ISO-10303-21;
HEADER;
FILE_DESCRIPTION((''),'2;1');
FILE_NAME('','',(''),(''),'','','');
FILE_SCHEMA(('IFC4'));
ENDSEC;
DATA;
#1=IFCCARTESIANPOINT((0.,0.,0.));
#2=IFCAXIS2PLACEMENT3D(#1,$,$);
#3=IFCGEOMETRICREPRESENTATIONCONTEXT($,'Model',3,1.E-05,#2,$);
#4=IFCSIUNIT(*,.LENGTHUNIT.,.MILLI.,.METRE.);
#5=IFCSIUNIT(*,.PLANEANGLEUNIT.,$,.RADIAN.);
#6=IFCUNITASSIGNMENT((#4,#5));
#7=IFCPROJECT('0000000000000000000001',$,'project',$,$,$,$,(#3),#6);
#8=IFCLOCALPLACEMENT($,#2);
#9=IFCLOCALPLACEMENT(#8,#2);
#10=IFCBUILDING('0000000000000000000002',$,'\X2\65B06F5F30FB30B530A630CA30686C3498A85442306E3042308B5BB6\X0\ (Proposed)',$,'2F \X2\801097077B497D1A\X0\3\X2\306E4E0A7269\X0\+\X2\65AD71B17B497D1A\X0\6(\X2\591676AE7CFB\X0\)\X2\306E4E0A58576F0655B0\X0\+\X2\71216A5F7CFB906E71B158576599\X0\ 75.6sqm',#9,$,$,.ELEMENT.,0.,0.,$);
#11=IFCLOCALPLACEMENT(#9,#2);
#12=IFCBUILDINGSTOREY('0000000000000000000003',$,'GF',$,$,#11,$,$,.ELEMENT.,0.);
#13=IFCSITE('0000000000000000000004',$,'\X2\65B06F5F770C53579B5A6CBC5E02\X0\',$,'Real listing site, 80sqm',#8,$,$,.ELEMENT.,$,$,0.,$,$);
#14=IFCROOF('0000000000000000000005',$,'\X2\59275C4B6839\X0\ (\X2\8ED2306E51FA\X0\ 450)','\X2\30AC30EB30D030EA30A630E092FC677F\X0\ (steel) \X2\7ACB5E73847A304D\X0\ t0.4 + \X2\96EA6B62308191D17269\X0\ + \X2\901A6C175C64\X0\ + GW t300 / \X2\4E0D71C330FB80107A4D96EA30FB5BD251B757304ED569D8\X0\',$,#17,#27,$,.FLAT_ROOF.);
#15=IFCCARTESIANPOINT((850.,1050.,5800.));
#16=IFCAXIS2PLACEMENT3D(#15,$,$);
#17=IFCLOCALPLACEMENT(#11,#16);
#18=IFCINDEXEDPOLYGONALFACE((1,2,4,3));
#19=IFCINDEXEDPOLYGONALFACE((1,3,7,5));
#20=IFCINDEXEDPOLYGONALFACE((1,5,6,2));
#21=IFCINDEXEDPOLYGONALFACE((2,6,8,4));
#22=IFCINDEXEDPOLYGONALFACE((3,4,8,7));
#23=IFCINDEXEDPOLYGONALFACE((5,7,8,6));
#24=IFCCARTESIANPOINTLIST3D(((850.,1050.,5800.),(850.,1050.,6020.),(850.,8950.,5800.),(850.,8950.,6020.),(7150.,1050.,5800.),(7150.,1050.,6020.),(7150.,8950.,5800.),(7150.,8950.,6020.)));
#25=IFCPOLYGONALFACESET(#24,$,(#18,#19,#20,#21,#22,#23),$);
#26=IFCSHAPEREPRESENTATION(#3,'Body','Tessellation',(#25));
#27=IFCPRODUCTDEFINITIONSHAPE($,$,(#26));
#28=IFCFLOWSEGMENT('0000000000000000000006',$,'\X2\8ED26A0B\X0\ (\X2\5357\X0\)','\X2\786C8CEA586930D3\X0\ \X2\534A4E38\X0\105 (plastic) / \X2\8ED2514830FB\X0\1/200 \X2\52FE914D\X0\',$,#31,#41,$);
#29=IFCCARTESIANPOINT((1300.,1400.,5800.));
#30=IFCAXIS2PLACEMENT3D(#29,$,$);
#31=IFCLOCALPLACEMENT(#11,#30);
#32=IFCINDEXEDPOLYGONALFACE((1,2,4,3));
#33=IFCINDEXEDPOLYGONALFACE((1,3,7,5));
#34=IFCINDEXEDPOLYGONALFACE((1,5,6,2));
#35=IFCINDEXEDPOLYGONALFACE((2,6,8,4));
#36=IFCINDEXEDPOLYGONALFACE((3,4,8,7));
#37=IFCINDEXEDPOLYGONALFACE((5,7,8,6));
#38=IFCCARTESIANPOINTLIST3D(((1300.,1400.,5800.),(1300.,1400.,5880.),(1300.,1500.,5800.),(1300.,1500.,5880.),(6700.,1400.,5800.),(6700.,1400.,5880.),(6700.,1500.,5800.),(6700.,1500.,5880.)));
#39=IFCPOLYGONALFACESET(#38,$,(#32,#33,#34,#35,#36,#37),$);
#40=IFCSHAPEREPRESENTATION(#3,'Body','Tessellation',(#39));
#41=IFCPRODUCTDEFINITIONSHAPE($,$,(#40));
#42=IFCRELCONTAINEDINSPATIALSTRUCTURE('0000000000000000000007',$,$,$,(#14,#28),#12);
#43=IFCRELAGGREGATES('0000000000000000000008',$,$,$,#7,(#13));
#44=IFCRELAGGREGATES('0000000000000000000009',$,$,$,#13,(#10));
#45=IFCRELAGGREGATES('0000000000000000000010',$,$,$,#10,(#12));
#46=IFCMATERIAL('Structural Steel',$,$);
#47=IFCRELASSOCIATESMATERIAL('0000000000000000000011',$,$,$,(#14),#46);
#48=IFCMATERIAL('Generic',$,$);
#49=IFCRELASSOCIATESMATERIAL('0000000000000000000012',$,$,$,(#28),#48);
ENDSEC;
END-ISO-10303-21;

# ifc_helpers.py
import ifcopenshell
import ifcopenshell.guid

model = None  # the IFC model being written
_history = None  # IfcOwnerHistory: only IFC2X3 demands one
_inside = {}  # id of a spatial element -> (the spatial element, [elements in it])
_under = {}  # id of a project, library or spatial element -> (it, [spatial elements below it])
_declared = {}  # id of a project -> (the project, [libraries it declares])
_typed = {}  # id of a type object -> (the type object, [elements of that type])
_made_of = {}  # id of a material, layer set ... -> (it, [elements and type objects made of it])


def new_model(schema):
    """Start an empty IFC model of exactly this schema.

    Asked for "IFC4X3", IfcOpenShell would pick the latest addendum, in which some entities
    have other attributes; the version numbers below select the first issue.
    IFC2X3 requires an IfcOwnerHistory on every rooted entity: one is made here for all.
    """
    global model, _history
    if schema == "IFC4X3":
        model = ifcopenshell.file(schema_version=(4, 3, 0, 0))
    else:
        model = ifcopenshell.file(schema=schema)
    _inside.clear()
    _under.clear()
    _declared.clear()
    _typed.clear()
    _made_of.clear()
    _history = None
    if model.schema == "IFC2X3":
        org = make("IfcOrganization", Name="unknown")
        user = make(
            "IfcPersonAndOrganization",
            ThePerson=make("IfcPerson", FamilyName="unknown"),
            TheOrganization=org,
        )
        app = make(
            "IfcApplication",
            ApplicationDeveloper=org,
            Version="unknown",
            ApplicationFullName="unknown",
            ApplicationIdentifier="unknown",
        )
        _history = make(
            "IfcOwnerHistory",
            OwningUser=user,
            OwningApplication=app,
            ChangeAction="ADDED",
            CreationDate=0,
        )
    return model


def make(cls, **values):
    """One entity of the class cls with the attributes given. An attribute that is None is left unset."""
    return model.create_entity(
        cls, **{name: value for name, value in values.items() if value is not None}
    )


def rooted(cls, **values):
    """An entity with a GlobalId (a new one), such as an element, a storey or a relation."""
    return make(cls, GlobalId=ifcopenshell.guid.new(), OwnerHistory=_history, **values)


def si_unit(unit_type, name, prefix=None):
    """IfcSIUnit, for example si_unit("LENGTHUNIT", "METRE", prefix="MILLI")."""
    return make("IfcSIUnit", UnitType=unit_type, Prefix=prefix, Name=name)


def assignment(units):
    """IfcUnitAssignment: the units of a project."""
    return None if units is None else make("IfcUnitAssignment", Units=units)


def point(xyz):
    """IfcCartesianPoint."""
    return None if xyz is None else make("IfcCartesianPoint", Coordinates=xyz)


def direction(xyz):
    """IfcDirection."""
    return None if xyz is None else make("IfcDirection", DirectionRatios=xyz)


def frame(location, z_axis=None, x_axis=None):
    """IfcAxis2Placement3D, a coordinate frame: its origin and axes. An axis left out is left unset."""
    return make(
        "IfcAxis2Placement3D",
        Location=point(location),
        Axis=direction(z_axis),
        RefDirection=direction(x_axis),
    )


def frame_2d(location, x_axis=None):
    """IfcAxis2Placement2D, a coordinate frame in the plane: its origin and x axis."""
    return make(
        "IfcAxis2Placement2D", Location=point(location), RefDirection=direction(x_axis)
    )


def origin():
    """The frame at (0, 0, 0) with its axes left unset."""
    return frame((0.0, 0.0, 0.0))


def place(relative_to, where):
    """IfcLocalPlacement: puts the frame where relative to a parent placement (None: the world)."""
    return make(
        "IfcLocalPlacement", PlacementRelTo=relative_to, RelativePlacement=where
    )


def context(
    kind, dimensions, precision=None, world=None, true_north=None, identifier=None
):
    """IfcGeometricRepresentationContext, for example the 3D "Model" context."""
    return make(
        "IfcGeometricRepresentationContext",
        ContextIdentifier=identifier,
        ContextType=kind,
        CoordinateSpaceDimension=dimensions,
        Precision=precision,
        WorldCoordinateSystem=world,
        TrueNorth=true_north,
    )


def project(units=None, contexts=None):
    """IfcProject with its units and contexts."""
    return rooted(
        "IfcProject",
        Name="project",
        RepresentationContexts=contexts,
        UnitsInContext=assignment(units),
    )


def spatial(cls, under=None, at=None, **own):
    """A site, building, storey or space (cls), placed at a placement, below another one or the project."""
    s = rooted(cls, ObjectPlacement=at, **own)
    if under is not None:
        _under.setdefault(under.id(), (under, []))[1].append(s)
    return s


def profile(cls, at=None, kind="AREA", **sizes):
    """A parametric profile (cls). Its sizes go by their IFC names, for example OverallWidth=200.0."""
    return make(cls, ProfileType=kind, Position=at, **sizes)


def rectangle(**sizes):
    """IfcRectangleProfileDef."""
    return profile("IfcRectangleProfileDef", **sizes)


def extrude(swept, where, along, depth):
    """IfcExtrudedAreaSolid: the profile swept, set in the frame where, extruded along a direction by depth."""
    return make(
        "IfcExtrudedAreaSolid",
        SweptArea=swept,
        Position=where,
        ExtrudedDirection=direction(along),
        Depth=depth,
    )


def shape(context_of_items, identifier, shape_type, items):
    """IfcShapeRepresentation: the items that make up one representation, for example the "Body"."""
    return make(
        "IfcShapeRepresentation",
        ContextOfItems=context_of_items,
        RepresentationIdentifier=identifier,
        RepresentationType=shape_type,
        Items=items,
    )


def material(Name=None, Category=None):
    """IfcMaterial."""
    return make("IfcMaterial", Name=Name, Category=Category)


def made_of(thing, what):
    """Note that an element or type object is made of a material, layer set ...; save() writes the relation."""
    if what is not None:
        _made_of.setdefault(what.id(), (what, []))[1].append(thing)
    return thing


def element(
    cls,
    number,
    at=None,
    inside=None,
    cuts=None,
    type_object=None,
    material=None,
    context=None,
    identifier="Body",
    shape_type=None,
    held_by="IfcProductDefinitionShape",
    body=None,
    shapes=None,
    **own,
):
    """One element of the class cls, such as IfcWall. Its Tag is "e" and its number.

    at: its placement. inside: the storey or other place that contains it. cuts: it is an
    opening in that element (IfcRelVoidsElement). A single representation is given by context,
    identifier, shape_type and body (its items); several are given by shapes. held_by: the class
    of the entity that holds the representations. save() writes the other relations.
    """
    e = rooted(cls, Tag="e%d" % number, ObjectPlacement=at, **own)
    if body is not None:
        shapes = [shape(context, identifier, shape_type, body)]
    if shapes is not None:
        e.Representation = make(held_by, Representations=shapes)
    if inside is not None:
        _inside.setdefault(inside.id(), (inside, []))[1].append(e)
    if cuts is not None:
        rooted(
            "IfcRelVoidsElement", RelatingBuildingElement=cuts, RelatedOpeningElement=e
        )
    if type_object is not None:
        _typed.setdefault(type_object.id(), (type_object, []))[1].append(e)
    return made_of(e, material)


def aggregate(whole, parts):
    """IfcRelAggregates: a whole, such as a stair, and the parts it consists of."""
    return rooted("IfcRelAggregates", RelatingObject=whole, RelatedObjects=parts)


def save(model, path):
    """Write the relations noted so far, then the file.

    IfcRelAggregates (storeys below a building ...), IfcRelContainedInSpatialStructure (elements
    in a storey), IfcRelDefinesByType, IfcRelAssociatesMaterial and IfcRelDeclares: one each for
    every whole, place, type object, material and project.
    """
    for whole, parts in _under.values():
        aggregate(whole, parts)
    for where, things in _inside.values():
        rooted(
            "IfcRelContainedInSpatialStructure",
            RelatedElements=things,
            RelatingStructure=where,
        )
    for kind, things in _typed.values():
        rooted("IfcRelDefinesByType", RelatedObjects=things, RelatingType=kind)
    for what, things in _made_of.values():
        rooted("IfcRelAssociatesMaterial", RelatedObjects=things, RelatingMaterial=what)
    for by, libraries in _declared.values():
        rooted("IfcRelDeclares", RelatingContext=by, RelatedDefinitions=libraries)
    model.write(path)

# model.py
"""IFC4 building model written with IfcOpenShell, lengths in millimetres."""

from ifc_helpers import new_model, si_unit, frame, frame_2d, origin, place, context, project, spatial, rectangle, extrude, material, element, save


model = new_model("IFC4")

# Units and contexts
model_context = context("Model", 3, precision=1e-05, world=origin())
ifc_project = project(units=[si_unit("LENGTHUNIT", "METRE", prefix="MILLI"), si_unit("PLANEANGLEUNIT", "RADIAN")], contexts=[model_context])

# Site, building, storey
site_placement = place(None, origin())
site = spatial("IfcSite", under=ifc_project, at=site_placement, Name="新潟県南魚沼市", ObjectType="Real listing site, 80sqm", CompositionType="ELEMENT", RefElevation=0.0)
building_placement = place(site_placement, origin())
building = spatial("IfcBuilding", under=site, at=building_placement, Name="新潟・サウナと水風呂のある家 (Proposed)", ObjectType="2F 耐震等級3の上物+断熱等級6(外皮系)の上塗漆喰+無機系遮熱塗料 75.6sqm", CompositionType="ELEMENT", ElevationOfRefHeight=0.0, ElevationOfTerrain=0.0)
storey_placement = place(building_placement, origin())
storey = spatial("IfcBuildingStorey", under=building, at=storey_placement, Name="GF", CompositionType="ELEMENT", Elevation=0.0)

# Roof
ifc_material_1 = material(Name="Structural Steel")
roof_placement = place(storey_placement, frame((850.0, 1050.0, 5800.0)))
element("IfcRoof", 1, at=roof_placement, inside=storey, material=ifc_material_1, Name="大屋根 (軒の出 450)", Description="ガルバリウム鋼板 (steel) 立平葺き t0.4 + 雪止め金物 + 通気層 + GW t300 / 不燃・耐積雪・寒冷地仕様", PredefinedType="FLAT_ROOF", context=model_context, shape_type="SweptSolid", body=[
    extrude(rectangle(XDim=6300.0, YDim=7900.0, at=frame_2d((3150.0, 3950.0))), frame((850.0, 1050.0, 5800.0)), (0.0, 0.0, 1.0), 220.0),
])

# Flow segment
ifc_material_2 = material(Name="Generic")
flow_segment_placement = place(storey_placement, frame((1300.0, 1400.0, 5800.0)))
element("IfcFlowSegment", 2, at=flow_segment_placement, inside=storey, material=ifc_material_2, Name="軒樋 (南)", Description="硬質塩ビ 半丸105 (plastic) / 軒先・1/200 勾配", context=model_context, shape_type="SweptSolid", body=[
    extrude(rectangle(XDim=5400.0, YDim=100.0, at=frame_2d((2700.0, 50.0))), frame((1300.0, 1400.0, 5800.0)), (0.0, 0.0, 1.0), 80.0),
])

save(model, "model.ifc")
